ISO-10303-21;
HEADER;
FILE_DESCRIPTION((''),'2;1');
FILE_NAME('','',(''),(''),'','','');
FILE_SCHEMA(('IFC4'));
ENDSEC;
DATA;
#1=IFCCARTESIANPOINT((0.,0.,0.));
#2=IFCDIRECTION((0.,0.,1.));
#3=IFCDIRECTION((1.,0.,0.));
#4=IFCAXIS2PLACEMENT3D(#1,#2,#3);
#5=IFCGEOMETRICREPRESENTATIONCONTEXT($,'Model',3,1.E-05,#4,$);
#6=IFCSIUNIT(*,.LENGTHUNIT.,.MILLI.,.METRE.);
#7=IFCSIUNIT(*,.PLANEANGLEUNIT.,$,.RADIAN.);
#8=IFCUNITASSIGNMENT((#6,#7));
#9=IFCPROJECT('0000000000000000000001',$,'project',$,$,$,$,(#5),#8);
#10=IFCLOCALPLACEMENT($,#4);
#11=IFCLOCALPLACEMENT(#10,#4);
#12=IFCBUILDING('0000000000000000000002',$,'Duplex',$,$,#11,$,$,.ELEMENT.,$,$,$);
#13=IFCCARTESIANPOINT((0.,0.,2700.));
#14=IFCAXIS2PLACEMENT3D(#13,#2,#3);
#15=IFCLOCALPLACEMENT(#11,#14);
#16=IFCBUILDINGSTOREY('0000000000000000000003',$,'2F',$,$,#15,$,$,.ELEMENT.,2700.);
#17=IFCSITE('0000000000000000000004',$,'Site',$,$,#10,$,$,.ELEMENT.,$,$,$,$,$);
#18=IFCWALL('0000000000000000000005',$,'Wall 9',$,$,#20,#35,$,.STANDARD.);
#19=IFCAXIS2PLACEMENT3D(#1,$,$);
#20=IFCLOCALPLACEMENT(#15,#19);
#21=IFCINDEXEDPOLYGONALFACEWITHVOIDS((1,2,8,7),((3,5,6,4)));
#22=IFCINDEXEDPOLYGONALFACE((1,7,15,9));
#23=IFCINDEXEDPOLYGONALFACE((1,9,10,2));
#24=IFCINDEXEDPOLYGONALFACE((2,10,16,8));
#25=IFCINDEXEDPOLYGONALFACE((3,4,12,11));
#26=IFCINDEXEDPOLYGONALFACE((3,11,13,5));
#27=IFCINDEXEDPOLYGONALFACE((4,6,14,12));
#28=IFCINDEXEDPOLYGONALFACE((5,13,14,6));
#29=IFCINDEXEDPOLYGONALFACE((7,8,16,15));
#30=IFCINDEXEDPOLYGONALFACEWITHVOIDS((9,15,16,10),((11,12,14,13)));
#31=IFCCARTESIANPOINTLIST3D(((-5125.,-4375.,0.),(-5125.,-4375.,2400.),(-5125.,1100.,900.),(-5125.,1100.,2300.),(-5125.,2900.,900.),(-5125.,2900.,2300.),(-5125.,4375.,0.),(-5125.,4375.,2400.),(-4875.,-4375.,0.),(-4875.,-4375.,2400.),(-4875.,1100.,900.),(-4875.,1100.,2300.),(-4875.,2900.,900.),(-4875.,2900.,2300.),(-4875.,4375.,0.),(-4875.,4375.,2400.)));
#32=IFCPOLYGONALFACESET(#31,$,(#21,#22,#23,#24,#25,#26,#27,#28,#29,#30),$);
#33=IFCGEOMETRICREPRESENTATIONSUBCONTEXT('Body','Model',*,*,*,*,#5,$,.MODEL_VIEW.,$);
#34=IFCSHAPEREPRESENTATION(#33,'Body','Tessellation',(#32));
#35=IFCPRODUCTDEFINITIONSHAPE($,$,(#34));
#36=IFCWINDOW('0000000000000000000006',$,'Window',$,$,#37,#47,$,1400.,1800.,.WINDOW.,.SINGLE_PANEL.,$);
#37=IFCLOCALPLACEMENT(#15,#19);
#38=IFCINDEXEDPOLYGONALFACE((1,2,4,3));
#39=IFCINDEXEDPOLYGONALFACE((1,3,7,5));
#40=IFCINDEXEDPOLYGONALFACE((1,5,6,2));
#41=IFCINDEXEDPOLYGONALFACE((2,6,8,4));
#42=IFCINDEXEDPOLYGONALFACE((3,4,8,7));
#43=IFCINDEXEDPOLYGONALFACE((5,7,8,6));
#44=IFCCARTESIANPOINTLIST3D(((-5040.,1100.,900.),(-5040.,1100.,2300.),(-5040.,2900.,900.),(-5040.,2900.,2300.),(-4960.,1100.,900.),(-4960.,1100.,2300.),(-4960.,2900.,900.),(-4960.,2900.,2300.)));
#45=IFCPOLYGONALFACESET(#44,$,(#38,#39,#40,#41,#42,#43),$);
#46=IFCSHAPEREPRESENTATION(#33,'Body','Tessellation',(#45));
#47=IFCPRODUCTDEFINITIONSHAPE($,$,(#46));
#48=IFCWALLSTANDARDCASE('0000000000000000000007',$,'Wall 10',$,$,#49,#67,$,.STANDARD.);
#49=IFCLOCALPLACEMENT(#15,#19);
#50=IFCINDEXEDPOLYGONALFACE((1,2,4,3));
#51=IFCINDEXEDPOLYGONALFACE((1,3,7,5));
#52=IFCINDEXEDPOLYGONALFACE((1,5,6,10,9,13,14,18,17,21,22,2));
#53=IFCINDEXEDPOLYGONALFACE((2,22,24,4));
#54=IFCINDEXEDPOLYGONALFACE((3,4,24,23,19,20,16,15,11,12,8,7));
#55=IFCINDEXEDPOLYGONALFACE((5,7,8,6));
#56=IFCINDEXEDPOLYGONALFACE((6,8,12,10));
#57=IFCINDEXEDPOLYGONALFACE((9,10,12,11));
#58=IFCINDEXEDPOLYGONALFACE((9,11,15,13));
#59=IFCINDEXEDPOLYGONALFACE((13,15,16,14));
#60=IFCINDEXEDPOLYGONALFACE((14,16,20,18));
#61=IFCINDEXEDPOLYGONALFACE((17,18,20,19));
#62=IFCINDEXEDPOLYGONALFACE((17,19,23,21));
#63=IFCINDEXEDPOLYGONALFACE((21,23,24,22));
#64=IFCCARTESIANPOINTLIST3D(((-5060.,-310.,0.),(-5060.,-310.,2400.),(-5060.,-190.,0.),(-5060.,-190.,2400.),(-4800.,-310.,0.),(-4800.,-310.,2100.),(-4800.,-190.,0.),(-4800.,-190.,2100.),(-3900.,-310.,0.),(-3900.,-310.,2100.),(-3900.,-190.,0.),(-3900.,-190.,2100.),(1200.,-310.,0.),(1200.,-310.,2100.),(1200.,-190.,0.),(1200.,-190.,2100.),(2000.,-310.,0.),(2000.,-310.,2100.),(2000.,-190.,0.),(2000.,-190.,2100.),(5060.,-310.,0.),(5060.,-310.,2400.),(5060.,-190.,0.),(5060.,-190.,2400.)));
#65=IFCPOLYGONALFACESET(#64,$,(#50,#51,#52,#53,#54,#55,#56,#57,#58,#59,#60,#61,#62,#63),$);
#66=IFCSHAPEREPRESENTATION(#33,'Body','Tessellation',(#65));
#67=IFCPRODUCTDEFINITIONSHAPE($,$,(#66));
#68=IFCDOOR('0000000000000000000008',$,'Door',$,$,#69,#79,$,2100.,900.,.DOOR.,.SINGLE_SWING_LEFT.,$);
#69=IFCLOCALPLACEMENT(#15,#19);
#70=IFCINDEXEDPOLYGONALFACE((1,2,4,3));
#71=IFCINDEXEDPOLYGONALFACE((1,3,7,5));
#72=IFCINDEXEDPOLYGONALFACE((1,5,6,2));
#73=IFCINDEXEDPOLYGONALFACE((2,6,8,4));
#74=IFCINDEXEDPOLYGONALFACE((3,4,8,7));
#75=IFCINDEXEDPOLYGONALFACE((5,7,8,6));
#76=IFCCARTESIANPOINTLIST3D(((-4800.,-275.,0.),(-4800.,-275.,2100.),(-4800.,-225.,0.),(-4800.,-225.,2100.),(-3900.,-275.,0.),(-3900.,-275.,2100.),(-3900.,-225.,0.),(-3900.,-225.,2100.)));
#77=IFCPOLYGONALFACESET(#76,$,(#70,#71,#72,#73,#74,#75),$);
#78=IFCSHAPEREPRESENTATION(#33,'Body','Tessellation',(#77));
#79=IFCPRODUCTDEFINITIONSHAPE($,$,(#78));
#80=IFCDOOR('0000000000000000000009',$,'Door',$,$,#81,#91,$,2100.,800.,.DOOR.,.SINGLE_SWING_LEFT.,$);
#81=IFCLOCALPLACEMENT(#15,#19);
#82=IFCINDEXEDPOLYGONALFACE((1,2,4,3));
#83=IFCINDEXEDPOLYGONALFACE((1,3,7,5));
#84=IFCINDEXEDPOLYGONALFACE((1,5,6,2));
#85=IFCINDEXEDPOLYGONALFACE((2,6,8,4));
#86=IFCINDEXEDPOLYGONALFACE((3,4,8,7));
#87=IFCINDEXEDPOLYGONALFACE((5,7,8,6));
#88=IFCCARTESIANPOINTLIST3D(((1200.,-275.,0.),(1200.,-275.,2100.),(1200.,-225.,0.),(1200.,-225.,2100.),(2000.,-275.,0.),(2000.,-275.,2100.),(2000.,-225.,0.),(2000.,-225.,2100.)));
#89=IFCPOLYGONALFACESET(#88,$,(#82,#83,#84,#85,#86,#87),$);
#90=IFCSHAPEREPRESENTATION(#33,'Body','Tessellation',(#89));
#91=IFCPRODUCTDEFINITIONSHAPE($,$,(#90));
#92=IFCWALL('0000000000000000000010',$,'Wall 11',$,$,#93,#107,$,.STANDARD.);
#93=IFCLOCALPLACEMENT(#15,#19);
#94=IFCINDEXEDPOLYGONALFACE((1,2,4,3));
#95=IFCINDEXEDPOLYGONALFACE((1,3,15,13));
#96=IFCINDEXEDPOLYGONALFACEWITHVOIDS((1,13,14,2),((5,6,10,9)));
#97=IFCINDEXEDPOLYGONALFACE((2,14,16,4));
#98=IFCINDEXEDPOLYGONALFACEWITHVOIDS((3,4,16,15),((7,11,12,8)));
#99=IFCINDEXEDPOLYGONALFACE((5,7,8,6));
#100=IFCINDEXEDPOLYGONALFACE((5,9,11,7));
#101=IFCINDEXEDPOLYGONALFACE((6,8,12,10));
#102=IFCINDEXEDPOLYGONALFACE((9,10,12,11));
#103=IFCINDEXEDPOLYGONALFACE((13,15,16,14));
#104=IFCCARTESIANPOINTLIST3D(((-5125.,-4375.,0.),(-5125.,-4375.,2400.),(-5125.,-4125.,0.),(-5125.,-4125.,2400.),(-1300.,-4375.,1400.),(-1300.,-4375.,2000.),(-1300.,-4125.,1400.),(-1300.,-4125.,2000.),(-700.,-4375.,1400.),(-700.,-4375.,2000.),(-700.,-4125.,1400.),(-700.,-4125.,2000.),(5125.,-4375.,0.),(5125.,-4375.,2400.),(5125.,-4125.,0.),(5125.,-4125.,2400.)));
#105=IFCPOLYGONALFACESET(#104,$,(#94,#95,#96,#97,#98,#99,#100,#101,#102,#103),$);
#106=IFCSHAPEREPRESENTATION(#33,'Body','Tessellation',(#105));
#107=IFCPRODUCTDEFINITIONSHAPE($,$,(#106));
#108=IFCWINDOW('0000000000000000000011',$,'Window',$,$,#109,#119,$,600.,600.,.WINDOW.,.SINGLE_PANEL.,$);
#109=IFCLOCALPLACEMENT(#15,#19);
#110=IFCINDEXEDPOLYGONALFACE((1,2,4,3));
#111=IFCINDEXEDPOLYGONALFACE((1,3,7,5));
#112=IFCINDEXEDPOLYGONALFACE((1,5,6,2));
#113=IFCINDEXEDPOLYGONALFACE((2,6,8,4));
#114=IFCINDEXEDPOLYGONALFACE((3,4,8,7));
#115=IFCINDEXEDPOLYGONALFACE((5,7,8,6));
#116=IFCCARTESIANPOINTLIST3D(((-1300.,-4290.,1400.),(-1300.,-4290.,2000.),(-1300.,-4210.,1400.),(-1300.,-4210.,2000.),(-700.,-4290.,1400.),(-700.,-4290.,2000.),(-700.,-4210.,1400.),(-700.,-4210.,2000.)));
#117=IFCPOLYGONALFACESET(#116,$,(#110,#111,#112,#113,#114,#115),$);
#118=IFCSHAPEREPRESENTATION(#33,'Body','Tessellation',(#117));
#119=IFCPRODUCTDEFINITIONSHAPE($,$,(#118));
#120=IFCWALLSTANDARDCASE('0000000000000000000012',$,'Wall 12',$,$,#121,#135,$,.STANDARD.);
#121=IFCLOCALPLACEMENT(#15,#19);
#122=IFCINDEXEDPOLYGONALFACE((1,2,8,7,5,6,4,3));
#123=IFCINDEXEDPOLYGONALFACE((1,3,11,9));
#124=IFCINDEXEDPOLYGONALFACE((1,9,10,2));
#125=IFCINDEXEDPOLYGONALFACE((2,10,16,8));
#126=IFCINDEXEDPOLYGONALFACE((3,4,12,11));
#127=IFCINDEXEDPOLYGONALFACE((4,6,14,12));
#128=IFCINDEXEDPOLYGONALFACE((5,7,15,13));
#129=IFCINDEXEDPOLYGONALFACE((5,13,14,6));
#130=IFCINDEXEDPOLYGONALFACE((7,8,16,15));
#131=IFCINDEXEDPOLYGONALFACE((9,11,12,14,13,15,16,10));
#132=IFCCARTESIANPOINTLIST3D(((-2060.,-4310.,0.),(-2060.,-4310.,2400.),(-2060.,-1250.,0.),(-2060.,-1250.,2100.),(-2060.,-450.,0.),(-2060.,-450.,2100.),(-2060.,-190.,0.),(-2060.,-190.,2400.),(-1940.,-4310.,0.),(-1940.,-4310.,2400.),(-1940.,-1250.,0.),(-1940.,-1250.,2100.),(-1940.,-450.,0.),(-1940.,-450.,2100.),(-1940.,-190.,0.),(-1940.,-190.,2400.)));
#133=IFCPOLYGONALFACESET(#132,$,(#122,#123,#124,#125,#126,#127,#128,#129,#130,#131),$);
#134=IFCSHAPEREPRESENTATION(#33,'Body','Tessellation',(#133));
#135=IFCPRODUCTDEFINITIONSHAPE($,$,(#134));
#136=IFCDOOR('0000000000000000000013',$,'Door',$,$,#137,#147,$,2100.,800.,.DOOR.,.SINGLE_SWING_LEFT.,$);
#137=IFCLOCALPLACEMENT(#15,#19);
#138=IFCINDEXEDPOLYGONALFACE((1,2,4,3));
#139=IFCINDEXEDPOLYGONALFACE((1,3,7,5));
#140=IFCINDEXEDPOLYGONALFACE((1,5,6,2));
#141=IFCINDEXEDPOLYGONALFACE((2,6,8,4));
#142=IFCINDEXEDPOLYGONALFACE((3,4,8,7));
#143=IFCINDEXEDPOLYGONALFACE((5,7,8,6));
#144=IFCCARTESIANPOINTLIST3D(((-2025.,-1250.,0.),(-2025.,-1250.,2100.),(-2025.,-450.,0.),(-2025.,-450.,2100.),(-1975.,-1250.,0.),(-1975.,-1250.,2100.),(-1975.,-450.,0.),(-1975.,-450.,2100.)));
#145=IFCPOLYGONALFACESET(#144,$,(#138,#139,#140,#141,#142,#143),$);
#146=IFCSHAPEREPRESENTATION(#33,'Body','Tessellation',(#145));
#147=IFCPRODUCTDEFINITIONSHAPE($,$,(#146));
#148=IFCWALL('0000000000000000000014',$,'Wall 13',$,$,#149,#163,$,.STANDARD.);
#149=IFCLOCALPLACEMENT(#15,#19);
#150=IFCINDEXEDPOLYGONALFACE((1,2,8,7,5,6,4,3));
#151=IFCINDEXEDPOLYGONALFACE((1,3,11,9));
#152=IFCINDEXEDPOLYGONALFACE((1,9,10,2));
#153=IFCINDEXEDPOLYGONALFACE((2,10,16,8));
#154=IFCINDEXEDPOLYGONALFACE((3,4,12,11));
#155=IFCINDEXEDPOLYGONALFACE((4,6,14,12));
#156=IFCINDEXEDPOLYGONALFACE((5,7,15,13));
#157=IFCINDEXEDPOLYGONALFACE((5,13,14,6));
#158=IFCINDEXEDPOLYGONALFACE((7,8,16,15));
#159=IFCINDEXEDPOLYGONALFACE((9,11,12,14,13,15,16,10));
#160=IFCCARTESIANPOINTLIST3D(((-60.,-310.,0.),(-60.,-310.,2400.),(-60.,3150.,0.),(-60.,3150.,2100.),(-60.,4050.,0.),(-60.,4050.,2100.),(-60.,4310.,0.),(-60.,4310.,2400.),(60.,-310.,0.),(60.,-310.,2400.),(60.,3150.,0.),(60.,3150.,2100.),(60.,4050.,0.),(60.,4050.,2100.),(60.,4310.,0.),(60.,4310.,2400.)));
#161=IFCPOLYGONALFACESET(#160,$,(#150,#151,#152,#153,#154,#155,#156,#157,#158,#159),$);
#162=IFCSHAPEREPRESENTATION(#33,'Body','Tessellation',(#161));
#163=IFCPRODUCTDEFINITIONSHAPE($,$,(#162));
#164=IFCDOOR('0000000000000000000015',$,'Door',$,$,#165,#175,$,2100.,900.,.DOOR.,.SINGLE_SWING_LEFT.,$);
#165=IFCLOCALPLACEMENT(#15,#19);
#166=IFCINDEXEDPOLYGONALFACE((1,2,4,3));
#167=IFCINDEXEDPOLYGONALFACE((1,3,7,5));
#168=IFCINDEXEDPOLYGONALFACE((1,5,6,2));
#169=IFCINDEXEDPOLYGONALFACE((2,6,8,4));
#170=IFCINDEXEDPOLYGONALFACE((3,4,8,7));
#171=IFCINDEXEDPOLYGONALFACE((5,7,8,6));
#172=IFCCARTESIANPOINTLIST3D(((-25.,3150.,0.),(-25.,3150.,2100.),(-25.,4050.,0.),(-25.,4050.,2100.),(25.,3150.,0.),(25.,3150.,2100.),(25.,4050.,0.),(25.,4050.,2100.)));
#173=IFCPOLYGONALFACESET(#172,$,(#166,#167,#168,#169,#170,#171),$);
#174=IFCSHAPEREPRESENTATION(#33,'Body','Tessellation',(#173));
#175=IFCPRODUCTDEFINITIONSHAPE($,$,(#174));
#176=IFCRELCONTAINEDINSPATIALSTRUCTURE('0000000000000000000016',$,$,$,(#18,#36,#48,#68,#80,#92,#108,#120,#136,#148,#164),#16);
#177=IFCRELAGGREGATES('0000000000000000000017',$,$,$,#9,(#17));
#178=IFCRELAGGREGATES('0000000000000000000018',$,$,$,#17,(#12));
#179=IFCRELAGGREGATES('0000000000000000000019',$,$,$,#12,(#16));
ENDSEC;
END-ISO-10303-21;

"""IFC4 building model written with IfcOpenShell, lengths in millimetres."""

from ifc_helpers import new_model, si_unit, frame, frame_2d, origin, origin_with_axes, place, context, subcontext, project, spatial, rectangle, extrude, element, fill, save


model = new_model("IFC4")

# Units and contexts
model_context = context("Model", 3, precision=1e-05, world=origin_with_axes())
body_context = subcontext(model_context, "Body", "Model", "MODEL_VIEW")
ifc_project = project(units=[si_unit("LENGTHUNIT", "METRE", prefix="MILLI"), si_unit("PLANEANGLEUNIT", "RADIAN")], contexts=[model_context])

# Site, building, storey
site_placement = place(None, origin_with_axes())
site = spatial("IfcSite", under=ifc_project, at=site_placement, Name="Site", CompositionType="ELEMENT")
building_placement = place(site_placement, origin_with_axes())
building = spatial("IfcBuilding", under=site, at=building_placement, Name="Duplex", CompositionType="ELEMENT")
storey_placement = place(building_placement, frame((0.0, 0.0, 2700.0), z_axis=(0.0, 0.0, 1.0), x_axis=(1.0, 0.0, 0.0)))
storey = spatial("IfcBuildingStorey", under=building, at=storey_placement, Name="2F", CompositionType="ELEMENT", Elevation=2700.0)

# Wall, opening, window
wall_1_placement = place(storey_placement, frame((-5000.0, 4250.0, 0.0), z_axis=(0.0, 0.0, 1.0), x_axis=(0.0, -1.0, 0.0)))
wall_1 = element("IfcWall", 1, at=wall_1_placement, inside=storey, Name="Wall 9", PredefinedType="STANDARD", context=body_context, shape_type="SweptSolid", body=[
    extrude(rectangle(XDim=8750.0, YDim=250.0, at=frame_2d((4250.0, 0.0))), origin(), (0.0, 0.0, 1.0), 2400.0),
])
opening_1_placement = place(wall_1_placement, frame((1350.0, 0.0, 900.0), z_axis=(0.0, 0.0, 1.0), x_axis=(1.0, 0.0, 0.0)))
opening_1 = element("IfcOpeningElement", 2, at=opening_1_placement, cuts=wall_1, PredefinedType="OPENING", context=body_context, shape_type="SweptSolid", body=[
    extrude(rectangle(XDim=1800.0, YDim=350.0, at=frame_2d((900.0, 0.0))), origin(), (0.0, 0.0, 1.0), 1400.0),
])
window_1_placement = place(opening_1_placement, origin_with_axes())
window_1 = element("IfcWindow", 3, at=window_1_placement, inside=storey, Name="Window", OverallHeight=1400.0, OverallWidth=1800.0, PartitioningType="SINGLE_PANEL", PredefinedType="WINDOW", context=body_context, shape_type="SweptSolid", body=[
    extrude(rectangle(XDim=1800.0, YDim=80.0, at=frame_2d((900.0, 0.0))), origin(), (0.0, 0.0, 1.0), 1400.0),
])
fill(opening_1, window_1)

# Wall, openings, doors
wall_2_placement = place(storey_placement, frame((-5000.0, -250.0, 0.0), z_axis=(0.0, 0.0, 1.0), x_axis=(1.0, 0.0, 0.0)))
wall_2 = element("IfcWallStandardCase", 4, at=wall_2_placement, inside=storey, Name="Wall 10", PredefinedType="STANDARD", context=body_context, shape_type="SweptSolid", body=[
    extrude(rectangle(XDim=10120.0, YDim=120.0, at=frame_2d((5000.0, 0.0))), origin(), (0.0, 0.0, 1.0), 2400.0),
])
opening_2_placement = place(wall_2_placement, frame((200.0, 0.0, 0.0), z_axis=(0.0, 0.0, 1.0), x_axis=(1.0, 0.0, 0.0)))
opening_2 = element("IfcOpeningElement", 5, at=opening_2_placement, cuts=wall_2, PredefinedType="OPENING", context=body_context, shape_type="SweptSolid", body=[
    extrude(rectangle(XDim=900.0, YDim=220.0, at=frame_2d((450.0, 0.0))), origin(), (0.0, 0.0, 1.0), 2100.0),
])
opening_3_placement = place(wall_2_placement, frame((6200.0, 0.0, 0.0), z_axis=(0.0, 0.0, 1.0), x_axis=(1.0, 0.0, 0.0)))
opening_3 = element("IfcOpeningElement", 6, at=opening_3_placement, cuts=wall_2, PredefinedType="OPENING", context=body_context, shape_type="SweptSolid", body=[
    extrude(rectangle(XDim=800.0, YDim=220.0, at=frame_2d((400.0, 0.0))), origin(), (0.0, 0.0, 1.0), 2100.0),
])
door_1_placement = place(opening_2_placement, origin_with_axes())
door_1 = element("IfcDoor", 7, at=door_1_placement, inside=storey, Name="Door", OperationType="SINGLE_SWING_LEFT", OverallHeight=2100.0, OverallWidth=900.0, PredefinedType="DOOR", context=body_context, shape_type="SweptSolid", body=[
    extrude(rectangle(XDim=900.0, YDim=50.0, at=frame_2d((450.0, 0.0))), origin(), (0.0, 0.0, 1.0), 2100.0),
])
fill(opening_2, door_1)
door_2_placement = place(opening_3_placement, origin_with_axes())
door_2 = element("IfcDoor", 8, at=door_2_placement, inside=storey, Name="Door", OperationType="SINGLE_SWING_LEFT", OverallHeight=2100.0, OverallWidth=800.0, PredefinedType="DOOR", context=body_context, shape_type="SweptSolid", body=[
    extrude(rectangle(XDim=800.0, YDim=50.0, at=frame_2d((400.0, 0.0))), origin(), (0.0, 0.0, 1.0), 2100.0),
])
fill(opening_3, door_2)

# Wall, opening, window
wall_3_placement = place(storey_placement, frame((-5000.0, -4250.0, 0.0), z_axis=(0.0, 0.0, 1.0), x_axis=(1.0, 0.0, 0.0)))
wall_3 = element("IfcWall", 9, at=wall_3_placement, inside=storey, Name="Wall 11", PredefinedType="STANDARD", context=body_context, shape_type="SweptSolid", body=[
    extrude(rectangle(XDim=10250.0, YDim=250.0, at=frame_2d((5000.0, 0.0))), origin(), (0.0, 0.0, 1.0), 2400.0),
])
opening_4_placement = place(wall_3_placement, frame((3700.0, 0.0, 1400.0), z_axis=(0.0, 0.0, 1.0), x_axis=(1.0, 0.0, 0.0)))
opening_4 = element("IfcOpeningElement", 10, at=opening_4_placement, cuts=wall_3, PredefinedType="OPENING", context=body_context, shape_type="SweptSolid", body=[
    extrude(rectangle(XDim=600.0, YDim=350.0, at=frame_2d((300.0, 0.0))), origin(), (0.0, 0.0, 1.0), 600.0),
])
window_2_placement = place(opening_4_placement, origin_with_axes())
window_2 = element("IfcWindow", 11, at=window_2_placement, inside=storey, Name="Window", OverallHeight=600.0, OverallWidth=600.0, PartitioningType="SINGLE_PANEL", PredefinedType="WINDOW", context=body_context, shape_type="SweptSolid", body=[
    extrude(rectangle(XDim=600.0, YDim=80.0, at=frame_2d((300.0, 0.0))), origin(), (0.0, 0.0, 1.0), 600.0),
])
fill(opening_4, window_2)

# Walls, openings, doors
wall_4_placement = place(storey_placement, frame((-2000.0, -250.0, 0.0), z_axis=(0.0, 0.0, 1.0), x_axis=(0.0, -1.0, 0.0)))
wall_4 = element("IfcWallStandardCase", 12, at=wall_4_placement, inside=storey, Name="Wall 12", PredefinedType="STANDARD", context=body_context, shape_type="SweptSolid", body=[
    extrude(rectangle(XDim=4120.0, YDim=120.0, at=frame_2d((2000.0, 0.0))), origin(), (0.0, 0.0, 1.0), 2400.0),
])
opening_5_placement = place(wall_4_placement, frame((200.0, 0.0, 0.0), z_axis=(0.0, 0.0, 1.0), x_axis=(1.0, 0.0, 0.0)))
opening_5 = element("IfcOpeningElement", 13, at=opening_5_placement, cuts=wall_4, PredefinedType="OPENING", context=body_context, shape_type="SweptSolid", body=[
    extrude(rectangle(XDim=800.0, YDim=220.0, at=frame_2d((400.0, 0.0))), origin(), (0.0, 0.0, 1.0), 2100.0),
])
door_3_placement = place(opening_5_placement, origin_with_axes())
door_3 = element("IfcDoor", 14, at=door_3_placement, inside=storey, Name="Door", OperationType="SINGLE_SWING_LEFT", OverallHeight=2100.0, OverallWidth=800.0, PredefinedType="DOOR", context=body_context, shape_type="SweptSolid", body=[
    extrude(rectangle(XDim=800.0, YDim=50.0, at=frame_2d((400.0, 0.0))), origin(), (0.0, 0.0, 1.0), 2100.0),
])
fill(opening_5, door_3)
wall_5_placement = place(storey_placement, frame((0.0, 4250.0, 0.0), z_axis=(0.0, 0.0, 1.0), x_axis=(0.0, -1.0, 0.0)))
wall_5 = element("IfcWall", 15, at=wall_5_placement, inside=storey, Name="Wall 13", PredefinedType="STANDARD", context=body_context, shape_type="SweptSolid", body=[
    extrude(rectangle(XDim=4620.0, YDim=120.0, at=frame_2d((2250.0, 0.0))), origin(), (0.0, 0.0, 1.0), 2400.0),
])
opening_6_placement = place(wall_5_placement, frame((200.0, 0.0, 0.0), z_axis=(0.0, 0.0, 1.0), x_axis=(1.0, 0.0, 0.0)))
opening_6 = element("IfcOpeningElement", 16, at=opening_6_placement, cuts=wall_5, PredefinedType="OPENING", context=body_context, shape_type="SweptSolid", body=[
    extrude(rectangle(XDim=900.0, YDim=220.0, at=frame_2d((450.0, 0.0))), origin(), (0.0, 0.0, 1.0), 2100.0),
])
door_4_placement = place(opening_6_placement, origin_with_axes())
door_4 = element("IfcDoor", 17, at=door_4_placement, inside=storey, Name="Door", OperationType="SINGLE_SWING_LEFT", OverallHeight=2100.0, OverallWidth=900.0, PredefinedType="DOOR", context=body_context, shape_type="SweptSolid", body=[
    extrude(rectangle(XDim=900.0, YDim=50.0, at=frame_2d((450.0, 0.0))), origin(), (0.0, 0.0, 1.0), 2100.0),
])
fill(opening_6, door_4)

save(model, "model.ifc")
